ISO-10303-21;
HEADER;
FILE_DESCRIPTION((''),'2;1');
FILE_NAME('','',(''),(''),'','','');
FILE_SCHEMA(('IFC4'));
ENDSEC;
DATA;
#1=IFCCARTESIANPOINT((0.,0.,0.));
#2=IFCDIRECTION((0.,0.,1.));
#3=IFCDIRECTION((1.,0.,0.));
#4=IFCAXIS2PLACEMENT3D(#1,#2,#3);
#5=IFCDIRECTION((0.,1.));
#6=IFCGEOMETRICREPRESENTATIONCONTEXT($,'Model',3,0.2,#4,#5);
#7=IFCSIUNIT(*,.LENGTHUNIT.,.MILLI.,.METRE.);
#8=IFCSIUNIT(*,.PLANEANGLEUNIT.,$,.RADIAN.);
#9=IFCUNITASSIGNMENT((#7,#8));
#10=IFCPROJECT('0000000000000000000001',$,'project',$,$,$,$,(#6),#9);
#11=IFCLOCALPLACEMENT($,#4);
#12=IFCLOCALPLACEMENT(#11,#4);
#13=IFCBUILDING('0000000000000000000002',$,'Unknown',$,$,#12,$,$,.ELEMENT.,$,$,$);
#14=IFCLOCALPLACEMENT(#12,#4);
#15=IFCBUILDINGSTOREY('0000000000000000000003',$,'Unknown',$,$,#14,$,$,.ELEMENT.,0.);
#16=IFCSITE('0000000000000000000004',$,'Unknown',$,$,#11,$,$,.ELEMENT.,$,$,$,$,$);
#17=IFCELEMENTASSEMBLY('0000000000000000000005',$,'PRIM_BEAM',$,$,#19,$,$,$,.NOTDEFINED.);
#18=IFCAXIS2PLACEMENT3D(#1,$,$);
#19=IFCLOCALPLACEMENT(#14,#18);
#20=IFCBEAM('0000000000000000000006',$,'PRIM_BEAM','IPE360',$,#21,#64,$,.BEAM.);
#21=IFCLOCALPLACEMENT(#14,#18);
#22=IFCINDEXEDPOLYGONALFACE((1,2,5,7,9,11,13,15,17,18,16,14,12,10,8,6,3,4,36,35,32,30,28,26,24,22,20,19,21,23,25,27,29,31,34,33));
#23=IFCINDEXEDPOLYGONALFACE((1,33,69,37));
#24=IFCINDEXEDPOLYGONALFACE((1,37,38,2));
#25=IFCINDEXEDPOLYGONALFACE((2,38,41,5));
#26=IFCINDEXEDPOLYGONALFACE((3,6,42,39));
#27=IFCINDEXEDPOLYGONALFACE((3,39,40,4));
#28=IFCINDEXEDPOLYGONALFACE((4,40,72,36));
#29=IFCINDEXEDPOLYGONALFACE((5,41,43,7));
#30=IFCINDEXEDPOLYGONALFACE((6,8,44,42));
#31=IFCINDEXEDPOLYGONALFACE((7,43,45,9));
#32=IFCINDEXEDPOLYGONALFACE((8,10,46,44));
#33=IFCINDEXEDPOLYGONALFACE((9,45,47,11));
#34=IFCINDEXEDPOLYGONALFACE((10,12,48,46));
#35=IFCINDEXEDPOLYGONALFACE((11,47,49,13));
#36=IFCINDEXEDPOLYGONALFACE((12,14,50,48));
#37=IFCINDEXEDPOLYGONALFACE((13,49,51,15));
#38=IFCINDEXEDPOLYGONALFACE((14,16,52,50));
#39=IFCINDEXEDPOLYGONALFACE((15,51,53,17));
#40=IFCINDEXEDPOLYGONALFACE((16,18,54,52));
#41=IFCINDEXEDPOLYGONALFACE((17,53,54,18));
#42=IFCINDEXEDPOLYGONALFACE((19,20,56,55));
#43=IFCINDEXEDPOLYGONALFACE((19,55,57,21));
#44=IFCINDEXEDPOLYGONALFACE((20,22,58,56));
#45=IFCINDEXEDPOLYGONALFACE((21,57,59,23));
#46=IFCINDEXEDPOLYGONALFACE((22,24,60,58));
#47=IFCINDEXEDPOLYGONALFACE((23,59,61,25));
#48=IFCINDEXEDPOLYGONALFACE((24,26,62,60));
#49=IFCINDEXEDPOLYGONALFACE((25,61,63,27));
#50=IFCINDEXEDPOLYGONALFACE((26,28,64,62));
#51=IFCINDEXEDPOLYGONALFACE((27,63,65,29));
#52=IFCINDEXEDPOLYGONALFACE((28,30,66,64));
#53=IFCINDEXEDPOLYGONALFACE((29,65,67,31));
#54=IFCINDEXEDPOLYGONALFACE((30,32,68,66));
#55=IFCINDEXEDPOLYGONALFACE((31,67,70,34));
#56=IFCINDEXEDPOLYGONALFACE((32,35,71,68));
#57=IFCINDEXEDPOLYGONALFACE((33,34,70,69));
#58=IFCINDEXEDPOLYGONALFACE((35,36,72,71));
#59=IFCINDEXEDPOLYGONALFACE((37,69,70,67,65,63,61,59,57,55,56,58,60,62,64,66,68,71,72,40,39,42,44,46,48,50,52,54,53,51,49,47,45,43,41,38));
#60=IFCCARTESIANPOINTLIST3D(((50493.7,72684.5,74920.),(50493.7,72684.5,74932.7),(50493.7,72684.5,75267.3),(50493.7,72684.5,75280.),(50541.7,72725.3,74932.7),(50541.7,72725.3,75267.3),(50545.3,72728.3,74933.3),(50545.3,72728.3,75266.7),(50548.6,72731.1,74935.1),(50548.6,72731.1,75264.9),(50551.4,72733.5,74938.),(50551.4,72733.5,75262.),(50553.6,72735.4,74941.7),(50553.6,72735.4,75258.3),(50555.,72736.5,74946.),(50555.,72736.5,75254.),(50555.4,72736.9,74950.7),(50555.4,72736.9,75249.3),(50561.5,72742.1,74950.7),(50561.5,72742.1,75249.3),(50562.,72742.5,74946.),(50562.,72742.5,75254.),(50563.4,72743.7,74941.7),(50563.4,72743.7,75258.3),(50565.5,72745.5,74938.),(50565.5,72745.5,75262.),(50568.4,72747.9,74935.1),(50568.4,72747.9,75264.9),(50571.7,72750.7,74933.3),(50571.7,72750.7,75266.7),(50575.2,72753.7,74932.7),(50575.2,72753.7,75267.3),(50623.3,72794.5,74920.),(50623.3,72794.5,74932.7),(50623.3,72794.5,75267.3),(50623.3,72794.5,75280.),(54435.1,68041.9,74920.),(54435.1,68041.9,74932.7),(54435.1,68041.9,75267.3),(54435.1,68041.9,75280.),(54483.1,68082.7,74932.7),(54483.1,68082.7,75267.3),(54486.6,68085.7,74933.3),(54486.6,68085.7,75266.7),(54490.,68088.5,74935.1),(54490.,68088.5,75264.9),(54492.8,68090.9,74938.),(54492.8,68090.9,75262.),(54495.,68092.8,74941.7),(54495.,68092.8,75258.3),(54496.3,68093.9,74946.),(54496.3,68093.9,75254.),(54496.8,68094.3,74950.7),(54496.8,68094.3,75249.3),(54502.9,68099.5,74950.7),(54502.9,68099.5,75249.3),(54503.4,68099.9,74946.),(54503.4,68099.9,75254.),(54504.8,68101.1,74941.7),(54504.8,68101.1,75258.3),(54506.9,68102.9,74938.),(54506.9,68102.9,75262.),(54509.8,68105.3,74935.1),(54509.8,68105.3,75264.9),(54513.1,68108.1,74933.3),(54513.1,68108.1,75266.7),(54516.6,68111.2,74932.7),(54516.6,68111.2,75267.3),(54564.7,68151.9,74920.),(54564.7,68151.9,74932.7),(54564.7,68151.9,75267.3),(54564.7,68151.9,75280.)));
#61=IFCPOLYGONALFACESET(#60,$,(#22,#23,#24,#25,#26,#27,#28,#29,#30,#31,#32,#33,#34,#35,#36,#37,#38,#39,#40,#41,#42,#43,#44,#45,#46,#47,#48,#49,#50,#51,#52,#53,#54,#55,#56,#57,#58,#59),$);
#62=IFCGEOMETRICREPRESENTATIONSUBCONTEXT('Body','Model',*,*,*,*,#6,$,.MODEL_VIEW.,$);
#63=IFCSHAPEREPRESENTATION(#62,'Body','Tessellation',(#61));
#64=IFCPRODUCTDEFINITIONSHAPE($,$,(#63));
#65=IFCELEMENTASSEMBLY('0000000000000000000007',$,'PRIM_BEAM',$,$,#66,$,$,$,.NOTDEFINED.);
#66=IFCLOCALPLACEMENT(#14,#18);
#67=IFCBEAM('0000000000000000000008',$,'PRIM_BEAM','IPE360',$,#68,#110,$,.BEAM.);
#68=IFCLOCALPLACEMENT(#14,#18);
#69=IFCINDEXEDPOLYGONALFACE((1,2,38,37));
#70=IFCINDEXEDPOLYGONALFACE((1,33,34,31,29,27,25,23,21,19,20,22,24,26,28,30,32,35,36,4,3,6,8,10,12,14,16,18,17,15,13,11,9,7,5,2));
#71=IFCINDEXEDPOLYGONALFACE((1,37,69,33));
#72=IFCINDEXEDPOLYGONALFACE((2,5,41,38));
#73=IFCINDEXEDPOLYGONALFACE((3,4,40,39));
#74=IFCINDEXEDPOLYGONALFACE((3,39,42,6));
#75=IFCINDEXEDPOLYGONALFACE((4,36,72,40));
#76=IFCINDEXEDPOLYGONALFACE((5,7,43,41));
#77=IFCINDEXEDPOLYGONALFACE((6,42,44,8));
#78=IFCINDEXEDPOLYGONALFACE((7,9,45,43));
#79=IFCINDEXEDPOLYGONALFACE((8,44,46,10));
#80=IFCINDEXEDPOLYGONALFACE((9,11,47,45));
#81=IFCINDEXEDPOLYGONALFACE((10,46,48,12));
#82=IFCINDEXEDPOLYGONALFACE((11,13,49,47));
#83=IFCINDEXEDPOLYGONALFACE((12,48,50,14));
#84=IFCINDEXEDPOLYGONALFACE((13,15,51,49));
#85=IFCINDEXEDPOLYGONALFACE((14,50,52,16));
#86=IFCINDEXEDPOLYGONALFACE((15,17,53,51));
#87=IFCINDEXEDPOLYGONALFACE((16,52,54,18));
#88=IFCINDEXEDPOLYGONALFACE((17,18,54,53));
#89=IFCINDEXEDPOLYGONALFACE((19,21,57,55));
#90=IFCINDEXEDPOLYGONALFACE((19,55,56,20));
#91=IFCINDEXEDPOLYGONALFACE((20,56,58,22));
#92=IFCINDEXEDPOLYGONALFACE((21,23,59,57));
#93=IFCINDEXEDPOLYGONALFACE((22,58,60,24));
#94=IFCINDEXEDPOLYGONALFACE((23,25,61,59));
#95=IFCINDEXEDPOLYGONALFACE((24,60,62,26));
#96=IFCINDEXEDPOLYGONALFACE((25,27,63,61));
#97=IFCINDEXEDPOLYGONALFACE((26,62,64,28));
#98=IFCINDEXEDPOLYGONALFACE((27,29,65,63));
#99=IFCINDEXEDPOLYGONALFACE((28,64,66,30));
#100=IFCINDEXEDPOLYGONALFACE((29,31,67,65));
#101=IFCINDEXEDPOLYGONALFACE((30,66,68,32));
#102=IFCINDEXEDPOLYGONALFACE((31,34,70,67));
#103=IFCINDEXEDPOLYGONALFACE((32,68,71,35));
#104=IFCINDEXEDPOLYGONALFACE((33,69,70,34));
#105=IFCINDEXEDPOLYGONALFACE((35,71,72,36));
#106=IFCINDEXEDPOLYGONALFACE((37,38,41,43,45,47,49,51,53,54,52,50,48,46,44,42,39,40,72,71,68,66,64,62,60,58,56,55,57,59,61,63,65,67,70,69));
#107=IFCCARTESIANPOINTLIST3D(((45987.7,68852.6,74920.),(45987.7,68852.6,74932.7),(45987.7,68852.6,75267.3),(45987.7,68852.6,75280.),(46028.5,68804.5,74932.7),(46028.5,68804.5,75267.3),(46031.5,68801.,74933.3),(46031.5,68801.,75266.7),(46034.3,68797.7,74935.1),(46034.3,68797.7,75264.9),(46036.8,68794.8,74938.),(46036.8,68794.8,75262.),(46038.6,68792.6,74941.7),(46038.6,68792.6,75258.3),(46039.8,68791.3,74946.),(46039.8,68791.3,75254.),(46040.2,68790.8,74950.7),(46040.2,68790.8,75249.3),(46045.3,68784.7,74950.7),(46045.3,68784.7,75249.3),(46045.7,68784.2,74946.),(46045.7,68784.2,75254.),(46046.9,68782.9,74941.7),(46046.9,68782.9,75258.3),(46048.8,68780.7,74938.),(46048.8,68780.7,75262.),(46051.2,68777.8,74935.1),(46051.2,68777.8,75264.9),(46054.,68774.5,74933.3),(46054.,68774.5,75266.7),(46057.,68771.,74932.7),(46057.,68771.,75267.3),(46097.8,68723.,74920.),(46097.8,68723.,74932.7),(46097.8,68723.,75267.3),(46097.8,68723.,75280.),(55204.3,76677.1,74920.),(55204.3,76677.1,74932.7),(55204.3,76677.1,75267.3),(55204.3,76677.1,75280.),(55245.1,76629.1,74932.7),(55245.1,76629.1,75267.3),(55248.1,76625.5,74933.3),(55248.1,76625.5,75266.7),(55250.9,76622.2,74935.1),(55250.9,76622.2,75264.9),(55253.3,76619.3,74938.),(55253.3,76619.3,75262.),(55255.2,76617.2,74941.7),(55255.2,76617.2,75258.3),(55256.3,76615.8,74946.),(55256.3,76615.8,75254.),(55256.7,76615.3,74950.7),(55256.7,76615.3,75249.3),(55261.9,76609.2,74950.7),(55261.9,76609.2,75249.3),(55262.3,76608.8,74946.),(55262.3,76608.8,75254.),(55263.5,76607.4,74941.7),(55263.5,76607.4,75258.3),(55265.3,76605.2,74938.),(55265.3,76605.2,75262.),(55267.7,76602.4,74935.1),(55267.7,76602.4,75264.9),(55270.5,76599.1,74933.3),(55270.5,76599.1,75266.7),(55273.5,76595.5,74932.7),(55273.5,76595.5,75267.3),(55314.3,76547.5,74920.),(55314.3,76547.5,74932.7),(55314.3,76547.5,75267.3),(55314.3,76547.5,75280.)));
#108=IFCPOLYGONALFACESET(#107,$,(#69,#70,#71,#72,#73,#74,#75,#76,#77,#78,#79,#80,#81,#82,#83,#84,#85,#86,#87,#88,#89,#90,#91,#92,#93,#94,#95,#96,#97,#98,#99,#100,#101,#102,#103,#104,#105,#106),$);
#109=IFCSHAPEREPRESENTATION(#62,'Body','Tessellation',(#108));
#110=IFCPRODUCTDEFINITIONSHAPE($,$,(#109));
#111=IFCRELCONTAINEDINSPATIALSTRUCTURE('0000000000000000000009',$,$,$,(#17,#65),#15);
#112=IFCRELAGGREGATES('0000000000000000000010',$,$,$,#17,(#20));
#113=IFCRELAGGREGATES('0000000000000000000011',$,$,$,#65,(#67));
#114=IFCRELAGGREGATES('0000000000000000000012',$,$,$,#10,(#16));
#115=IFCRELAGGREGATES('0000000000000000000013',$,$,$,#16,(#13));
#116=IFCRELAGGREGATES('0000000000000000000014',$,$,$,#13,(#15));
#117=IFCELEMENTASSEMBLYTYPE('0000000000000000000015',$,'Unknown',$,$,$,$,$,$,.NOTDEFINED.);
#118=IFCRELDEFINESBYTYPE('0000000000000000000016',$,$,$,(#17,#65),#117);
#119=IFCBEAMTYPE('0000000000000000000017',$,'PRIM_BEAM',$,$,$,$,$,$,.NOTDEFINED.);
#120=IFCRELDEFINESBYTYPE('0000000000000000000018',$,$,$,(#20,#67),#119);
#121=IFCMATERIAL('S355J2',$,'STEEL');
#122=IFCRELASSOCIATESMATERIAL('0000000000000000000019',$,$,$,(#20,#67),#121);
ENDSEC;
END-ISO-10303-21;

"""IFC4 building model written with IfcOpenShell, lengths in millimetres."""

from ifc_helpers import new_model, si_unit, direction, frame, origin_with_axes, origin_2d_with_axis, place, context, subcontext, project, spatial, i_section, extrude, material, material_profile, profile_set, profile_usage, type_object, element, aggregate, save


model = new_model("IFC4")

# Units and contexts
model_context = context("Model", 3, precision=0.2, world=origin_with_axes(), true_north=direction((0.0, 1.0)))
body_context = subcontext(model_context, "Body", "Model", "MODEL_VIEW")
ifc_project = project(units=[si_unit("LENGTHUNIT", "METRE", prefix="MILLI"), si_unit("PLANEANGLEUNIT", "RADIAN")], contexts=[model_context])

# Site, building, storey
site_placement = place(None, origin_with_axes())
site = spatial("IfcSite", under=ifc_project, at=site_placement, Name="Unknown", CompositionType="ELEMENT")
building_placement = place(site_placement, origin_with_axes())
building = spatial("IfcBuilding", under=site, at=building_placement, Name="Unknown", CompositionType="ELEMENT")
storey_placement = place(building_placement, origin_with_axes())
storey = spatial("IfcBuildingStorey", under=building, at=storey_placement, Name="Unknown", CompositionType="ELEMENT", Elevation=0.0)

# Shared definitions
element_assembly_type = type_object("IfcElementAssemblyType", Name="Unknown", PredefinedType="NOTDEFINED")
ifc_material_1 = material(Name="S355J2", Category="STEEL")

# Element assemblies, beams
ifc_material_profile_1 = material_profile(ifc_material_1, i_section(OverallWidth=170.0, OverallDepth=360.0, WebThickness=8.0, FlangeThickness=12.7, FilletRadius=18.0, FlangeEdgeRadius=0.0, FlangeSlope=0.0, at=origin_2d_with_axis()), Name="IPE360")
ifc_profile_set_1 = profile_set([ifc_material_profile_1])
ifc_profile_usage_1 = profile_usage(ifc_profile_set_1, cardinal=2)
beam_type_1 = type_object("IfcBeamType", Name="PRIM_BEAM")
assembly_1_placement = place(storey_placement, frame((54499.9, 68096.9, 75100.0), z_axis=(0.762329, 0.64719, 0.0), x_axis=(-0.64719, 0.762329, 0.0)))
assembly_1 = element("IfcElementAssembly", 1, at=assembly_1_placement, inside=storey, type_object=element_assembly_type, Name="PRIM_BEAM", PredefinedType="NOTDEFINED")
beam_1_placement = place(assembly_1_placement, origin_with_axes())
beam_1 = element("IfcBeam", 2, at=beam_1_placement, type_object=beam_type_1, material=ifc_profile_usage_1, Name="PRIM_BEAM", Description="IPE360", PredefinedType="BEAM", context=body_context, shape_type="SolidModel", body=[
    extrude(i_section(OverallWidth=170.0, OverallDepth=360.0, WebThickness=8.0, FlangeThickness=12.7, FilletRadius=18.0, FlangeEdgeRadius=0.0, FlangeSlope=0.0, at=origin_2d_with_axis()), frame((0.0, 0.0, 0.0), z_axis=(-1.0, 0.0, 0.0), x_axis=(0.0, 0.0, 1.0)), (0.0, 0.0, -1.0), 6090.0),
])
aggregate(assembly_1, [beam_1])
assembly_2_placement = place(storey_placement, frame((46042.8, 68787.8, 75100.0), z_axis=(0.64719, -0.762329, 0.0), x_axis=(0.762329, 0.64719, 0.0)))
assembly_2 = element("IfcElementAssembly", 3, at=assembly_2_placement, inside=storey, type_object=element_assembly_type, Name="PRIM_BEAM", PredefinedType="NOTDEFINED")
beam_2_placement = place(assembly_2_placement, origin_with_axes())
beam_2 = element("IfcBeam", 4, at=beam_2_placement, type_object=beam_type_1, material=ifc_profile_usage_1, Name="PRIM_BEAM", Description="IPE360", PredefinedType="BEAM", context=body_context, shape_type="SolidModel", body=[
    extrude(i_section(OverallWidth=170.0, OverallDepth=360.0, WebThickness=8.0, FlangeThickness=12.7, FilletRadius=18.0, FlangeEdgeRadius=0.0, FlangeSlope=0.0, at=origin_2d_with_axis()), frame((0.0, 0.0, 0.0), z_axis=(-1.0, 0.0, 0.0), x_axis=(0.0, 0.0, 1.0)), (0.0, 0.0, -1.0), 12090.0),
])
aggregate(assembly_2, [beam_2])

save(model, "model.ifc")
